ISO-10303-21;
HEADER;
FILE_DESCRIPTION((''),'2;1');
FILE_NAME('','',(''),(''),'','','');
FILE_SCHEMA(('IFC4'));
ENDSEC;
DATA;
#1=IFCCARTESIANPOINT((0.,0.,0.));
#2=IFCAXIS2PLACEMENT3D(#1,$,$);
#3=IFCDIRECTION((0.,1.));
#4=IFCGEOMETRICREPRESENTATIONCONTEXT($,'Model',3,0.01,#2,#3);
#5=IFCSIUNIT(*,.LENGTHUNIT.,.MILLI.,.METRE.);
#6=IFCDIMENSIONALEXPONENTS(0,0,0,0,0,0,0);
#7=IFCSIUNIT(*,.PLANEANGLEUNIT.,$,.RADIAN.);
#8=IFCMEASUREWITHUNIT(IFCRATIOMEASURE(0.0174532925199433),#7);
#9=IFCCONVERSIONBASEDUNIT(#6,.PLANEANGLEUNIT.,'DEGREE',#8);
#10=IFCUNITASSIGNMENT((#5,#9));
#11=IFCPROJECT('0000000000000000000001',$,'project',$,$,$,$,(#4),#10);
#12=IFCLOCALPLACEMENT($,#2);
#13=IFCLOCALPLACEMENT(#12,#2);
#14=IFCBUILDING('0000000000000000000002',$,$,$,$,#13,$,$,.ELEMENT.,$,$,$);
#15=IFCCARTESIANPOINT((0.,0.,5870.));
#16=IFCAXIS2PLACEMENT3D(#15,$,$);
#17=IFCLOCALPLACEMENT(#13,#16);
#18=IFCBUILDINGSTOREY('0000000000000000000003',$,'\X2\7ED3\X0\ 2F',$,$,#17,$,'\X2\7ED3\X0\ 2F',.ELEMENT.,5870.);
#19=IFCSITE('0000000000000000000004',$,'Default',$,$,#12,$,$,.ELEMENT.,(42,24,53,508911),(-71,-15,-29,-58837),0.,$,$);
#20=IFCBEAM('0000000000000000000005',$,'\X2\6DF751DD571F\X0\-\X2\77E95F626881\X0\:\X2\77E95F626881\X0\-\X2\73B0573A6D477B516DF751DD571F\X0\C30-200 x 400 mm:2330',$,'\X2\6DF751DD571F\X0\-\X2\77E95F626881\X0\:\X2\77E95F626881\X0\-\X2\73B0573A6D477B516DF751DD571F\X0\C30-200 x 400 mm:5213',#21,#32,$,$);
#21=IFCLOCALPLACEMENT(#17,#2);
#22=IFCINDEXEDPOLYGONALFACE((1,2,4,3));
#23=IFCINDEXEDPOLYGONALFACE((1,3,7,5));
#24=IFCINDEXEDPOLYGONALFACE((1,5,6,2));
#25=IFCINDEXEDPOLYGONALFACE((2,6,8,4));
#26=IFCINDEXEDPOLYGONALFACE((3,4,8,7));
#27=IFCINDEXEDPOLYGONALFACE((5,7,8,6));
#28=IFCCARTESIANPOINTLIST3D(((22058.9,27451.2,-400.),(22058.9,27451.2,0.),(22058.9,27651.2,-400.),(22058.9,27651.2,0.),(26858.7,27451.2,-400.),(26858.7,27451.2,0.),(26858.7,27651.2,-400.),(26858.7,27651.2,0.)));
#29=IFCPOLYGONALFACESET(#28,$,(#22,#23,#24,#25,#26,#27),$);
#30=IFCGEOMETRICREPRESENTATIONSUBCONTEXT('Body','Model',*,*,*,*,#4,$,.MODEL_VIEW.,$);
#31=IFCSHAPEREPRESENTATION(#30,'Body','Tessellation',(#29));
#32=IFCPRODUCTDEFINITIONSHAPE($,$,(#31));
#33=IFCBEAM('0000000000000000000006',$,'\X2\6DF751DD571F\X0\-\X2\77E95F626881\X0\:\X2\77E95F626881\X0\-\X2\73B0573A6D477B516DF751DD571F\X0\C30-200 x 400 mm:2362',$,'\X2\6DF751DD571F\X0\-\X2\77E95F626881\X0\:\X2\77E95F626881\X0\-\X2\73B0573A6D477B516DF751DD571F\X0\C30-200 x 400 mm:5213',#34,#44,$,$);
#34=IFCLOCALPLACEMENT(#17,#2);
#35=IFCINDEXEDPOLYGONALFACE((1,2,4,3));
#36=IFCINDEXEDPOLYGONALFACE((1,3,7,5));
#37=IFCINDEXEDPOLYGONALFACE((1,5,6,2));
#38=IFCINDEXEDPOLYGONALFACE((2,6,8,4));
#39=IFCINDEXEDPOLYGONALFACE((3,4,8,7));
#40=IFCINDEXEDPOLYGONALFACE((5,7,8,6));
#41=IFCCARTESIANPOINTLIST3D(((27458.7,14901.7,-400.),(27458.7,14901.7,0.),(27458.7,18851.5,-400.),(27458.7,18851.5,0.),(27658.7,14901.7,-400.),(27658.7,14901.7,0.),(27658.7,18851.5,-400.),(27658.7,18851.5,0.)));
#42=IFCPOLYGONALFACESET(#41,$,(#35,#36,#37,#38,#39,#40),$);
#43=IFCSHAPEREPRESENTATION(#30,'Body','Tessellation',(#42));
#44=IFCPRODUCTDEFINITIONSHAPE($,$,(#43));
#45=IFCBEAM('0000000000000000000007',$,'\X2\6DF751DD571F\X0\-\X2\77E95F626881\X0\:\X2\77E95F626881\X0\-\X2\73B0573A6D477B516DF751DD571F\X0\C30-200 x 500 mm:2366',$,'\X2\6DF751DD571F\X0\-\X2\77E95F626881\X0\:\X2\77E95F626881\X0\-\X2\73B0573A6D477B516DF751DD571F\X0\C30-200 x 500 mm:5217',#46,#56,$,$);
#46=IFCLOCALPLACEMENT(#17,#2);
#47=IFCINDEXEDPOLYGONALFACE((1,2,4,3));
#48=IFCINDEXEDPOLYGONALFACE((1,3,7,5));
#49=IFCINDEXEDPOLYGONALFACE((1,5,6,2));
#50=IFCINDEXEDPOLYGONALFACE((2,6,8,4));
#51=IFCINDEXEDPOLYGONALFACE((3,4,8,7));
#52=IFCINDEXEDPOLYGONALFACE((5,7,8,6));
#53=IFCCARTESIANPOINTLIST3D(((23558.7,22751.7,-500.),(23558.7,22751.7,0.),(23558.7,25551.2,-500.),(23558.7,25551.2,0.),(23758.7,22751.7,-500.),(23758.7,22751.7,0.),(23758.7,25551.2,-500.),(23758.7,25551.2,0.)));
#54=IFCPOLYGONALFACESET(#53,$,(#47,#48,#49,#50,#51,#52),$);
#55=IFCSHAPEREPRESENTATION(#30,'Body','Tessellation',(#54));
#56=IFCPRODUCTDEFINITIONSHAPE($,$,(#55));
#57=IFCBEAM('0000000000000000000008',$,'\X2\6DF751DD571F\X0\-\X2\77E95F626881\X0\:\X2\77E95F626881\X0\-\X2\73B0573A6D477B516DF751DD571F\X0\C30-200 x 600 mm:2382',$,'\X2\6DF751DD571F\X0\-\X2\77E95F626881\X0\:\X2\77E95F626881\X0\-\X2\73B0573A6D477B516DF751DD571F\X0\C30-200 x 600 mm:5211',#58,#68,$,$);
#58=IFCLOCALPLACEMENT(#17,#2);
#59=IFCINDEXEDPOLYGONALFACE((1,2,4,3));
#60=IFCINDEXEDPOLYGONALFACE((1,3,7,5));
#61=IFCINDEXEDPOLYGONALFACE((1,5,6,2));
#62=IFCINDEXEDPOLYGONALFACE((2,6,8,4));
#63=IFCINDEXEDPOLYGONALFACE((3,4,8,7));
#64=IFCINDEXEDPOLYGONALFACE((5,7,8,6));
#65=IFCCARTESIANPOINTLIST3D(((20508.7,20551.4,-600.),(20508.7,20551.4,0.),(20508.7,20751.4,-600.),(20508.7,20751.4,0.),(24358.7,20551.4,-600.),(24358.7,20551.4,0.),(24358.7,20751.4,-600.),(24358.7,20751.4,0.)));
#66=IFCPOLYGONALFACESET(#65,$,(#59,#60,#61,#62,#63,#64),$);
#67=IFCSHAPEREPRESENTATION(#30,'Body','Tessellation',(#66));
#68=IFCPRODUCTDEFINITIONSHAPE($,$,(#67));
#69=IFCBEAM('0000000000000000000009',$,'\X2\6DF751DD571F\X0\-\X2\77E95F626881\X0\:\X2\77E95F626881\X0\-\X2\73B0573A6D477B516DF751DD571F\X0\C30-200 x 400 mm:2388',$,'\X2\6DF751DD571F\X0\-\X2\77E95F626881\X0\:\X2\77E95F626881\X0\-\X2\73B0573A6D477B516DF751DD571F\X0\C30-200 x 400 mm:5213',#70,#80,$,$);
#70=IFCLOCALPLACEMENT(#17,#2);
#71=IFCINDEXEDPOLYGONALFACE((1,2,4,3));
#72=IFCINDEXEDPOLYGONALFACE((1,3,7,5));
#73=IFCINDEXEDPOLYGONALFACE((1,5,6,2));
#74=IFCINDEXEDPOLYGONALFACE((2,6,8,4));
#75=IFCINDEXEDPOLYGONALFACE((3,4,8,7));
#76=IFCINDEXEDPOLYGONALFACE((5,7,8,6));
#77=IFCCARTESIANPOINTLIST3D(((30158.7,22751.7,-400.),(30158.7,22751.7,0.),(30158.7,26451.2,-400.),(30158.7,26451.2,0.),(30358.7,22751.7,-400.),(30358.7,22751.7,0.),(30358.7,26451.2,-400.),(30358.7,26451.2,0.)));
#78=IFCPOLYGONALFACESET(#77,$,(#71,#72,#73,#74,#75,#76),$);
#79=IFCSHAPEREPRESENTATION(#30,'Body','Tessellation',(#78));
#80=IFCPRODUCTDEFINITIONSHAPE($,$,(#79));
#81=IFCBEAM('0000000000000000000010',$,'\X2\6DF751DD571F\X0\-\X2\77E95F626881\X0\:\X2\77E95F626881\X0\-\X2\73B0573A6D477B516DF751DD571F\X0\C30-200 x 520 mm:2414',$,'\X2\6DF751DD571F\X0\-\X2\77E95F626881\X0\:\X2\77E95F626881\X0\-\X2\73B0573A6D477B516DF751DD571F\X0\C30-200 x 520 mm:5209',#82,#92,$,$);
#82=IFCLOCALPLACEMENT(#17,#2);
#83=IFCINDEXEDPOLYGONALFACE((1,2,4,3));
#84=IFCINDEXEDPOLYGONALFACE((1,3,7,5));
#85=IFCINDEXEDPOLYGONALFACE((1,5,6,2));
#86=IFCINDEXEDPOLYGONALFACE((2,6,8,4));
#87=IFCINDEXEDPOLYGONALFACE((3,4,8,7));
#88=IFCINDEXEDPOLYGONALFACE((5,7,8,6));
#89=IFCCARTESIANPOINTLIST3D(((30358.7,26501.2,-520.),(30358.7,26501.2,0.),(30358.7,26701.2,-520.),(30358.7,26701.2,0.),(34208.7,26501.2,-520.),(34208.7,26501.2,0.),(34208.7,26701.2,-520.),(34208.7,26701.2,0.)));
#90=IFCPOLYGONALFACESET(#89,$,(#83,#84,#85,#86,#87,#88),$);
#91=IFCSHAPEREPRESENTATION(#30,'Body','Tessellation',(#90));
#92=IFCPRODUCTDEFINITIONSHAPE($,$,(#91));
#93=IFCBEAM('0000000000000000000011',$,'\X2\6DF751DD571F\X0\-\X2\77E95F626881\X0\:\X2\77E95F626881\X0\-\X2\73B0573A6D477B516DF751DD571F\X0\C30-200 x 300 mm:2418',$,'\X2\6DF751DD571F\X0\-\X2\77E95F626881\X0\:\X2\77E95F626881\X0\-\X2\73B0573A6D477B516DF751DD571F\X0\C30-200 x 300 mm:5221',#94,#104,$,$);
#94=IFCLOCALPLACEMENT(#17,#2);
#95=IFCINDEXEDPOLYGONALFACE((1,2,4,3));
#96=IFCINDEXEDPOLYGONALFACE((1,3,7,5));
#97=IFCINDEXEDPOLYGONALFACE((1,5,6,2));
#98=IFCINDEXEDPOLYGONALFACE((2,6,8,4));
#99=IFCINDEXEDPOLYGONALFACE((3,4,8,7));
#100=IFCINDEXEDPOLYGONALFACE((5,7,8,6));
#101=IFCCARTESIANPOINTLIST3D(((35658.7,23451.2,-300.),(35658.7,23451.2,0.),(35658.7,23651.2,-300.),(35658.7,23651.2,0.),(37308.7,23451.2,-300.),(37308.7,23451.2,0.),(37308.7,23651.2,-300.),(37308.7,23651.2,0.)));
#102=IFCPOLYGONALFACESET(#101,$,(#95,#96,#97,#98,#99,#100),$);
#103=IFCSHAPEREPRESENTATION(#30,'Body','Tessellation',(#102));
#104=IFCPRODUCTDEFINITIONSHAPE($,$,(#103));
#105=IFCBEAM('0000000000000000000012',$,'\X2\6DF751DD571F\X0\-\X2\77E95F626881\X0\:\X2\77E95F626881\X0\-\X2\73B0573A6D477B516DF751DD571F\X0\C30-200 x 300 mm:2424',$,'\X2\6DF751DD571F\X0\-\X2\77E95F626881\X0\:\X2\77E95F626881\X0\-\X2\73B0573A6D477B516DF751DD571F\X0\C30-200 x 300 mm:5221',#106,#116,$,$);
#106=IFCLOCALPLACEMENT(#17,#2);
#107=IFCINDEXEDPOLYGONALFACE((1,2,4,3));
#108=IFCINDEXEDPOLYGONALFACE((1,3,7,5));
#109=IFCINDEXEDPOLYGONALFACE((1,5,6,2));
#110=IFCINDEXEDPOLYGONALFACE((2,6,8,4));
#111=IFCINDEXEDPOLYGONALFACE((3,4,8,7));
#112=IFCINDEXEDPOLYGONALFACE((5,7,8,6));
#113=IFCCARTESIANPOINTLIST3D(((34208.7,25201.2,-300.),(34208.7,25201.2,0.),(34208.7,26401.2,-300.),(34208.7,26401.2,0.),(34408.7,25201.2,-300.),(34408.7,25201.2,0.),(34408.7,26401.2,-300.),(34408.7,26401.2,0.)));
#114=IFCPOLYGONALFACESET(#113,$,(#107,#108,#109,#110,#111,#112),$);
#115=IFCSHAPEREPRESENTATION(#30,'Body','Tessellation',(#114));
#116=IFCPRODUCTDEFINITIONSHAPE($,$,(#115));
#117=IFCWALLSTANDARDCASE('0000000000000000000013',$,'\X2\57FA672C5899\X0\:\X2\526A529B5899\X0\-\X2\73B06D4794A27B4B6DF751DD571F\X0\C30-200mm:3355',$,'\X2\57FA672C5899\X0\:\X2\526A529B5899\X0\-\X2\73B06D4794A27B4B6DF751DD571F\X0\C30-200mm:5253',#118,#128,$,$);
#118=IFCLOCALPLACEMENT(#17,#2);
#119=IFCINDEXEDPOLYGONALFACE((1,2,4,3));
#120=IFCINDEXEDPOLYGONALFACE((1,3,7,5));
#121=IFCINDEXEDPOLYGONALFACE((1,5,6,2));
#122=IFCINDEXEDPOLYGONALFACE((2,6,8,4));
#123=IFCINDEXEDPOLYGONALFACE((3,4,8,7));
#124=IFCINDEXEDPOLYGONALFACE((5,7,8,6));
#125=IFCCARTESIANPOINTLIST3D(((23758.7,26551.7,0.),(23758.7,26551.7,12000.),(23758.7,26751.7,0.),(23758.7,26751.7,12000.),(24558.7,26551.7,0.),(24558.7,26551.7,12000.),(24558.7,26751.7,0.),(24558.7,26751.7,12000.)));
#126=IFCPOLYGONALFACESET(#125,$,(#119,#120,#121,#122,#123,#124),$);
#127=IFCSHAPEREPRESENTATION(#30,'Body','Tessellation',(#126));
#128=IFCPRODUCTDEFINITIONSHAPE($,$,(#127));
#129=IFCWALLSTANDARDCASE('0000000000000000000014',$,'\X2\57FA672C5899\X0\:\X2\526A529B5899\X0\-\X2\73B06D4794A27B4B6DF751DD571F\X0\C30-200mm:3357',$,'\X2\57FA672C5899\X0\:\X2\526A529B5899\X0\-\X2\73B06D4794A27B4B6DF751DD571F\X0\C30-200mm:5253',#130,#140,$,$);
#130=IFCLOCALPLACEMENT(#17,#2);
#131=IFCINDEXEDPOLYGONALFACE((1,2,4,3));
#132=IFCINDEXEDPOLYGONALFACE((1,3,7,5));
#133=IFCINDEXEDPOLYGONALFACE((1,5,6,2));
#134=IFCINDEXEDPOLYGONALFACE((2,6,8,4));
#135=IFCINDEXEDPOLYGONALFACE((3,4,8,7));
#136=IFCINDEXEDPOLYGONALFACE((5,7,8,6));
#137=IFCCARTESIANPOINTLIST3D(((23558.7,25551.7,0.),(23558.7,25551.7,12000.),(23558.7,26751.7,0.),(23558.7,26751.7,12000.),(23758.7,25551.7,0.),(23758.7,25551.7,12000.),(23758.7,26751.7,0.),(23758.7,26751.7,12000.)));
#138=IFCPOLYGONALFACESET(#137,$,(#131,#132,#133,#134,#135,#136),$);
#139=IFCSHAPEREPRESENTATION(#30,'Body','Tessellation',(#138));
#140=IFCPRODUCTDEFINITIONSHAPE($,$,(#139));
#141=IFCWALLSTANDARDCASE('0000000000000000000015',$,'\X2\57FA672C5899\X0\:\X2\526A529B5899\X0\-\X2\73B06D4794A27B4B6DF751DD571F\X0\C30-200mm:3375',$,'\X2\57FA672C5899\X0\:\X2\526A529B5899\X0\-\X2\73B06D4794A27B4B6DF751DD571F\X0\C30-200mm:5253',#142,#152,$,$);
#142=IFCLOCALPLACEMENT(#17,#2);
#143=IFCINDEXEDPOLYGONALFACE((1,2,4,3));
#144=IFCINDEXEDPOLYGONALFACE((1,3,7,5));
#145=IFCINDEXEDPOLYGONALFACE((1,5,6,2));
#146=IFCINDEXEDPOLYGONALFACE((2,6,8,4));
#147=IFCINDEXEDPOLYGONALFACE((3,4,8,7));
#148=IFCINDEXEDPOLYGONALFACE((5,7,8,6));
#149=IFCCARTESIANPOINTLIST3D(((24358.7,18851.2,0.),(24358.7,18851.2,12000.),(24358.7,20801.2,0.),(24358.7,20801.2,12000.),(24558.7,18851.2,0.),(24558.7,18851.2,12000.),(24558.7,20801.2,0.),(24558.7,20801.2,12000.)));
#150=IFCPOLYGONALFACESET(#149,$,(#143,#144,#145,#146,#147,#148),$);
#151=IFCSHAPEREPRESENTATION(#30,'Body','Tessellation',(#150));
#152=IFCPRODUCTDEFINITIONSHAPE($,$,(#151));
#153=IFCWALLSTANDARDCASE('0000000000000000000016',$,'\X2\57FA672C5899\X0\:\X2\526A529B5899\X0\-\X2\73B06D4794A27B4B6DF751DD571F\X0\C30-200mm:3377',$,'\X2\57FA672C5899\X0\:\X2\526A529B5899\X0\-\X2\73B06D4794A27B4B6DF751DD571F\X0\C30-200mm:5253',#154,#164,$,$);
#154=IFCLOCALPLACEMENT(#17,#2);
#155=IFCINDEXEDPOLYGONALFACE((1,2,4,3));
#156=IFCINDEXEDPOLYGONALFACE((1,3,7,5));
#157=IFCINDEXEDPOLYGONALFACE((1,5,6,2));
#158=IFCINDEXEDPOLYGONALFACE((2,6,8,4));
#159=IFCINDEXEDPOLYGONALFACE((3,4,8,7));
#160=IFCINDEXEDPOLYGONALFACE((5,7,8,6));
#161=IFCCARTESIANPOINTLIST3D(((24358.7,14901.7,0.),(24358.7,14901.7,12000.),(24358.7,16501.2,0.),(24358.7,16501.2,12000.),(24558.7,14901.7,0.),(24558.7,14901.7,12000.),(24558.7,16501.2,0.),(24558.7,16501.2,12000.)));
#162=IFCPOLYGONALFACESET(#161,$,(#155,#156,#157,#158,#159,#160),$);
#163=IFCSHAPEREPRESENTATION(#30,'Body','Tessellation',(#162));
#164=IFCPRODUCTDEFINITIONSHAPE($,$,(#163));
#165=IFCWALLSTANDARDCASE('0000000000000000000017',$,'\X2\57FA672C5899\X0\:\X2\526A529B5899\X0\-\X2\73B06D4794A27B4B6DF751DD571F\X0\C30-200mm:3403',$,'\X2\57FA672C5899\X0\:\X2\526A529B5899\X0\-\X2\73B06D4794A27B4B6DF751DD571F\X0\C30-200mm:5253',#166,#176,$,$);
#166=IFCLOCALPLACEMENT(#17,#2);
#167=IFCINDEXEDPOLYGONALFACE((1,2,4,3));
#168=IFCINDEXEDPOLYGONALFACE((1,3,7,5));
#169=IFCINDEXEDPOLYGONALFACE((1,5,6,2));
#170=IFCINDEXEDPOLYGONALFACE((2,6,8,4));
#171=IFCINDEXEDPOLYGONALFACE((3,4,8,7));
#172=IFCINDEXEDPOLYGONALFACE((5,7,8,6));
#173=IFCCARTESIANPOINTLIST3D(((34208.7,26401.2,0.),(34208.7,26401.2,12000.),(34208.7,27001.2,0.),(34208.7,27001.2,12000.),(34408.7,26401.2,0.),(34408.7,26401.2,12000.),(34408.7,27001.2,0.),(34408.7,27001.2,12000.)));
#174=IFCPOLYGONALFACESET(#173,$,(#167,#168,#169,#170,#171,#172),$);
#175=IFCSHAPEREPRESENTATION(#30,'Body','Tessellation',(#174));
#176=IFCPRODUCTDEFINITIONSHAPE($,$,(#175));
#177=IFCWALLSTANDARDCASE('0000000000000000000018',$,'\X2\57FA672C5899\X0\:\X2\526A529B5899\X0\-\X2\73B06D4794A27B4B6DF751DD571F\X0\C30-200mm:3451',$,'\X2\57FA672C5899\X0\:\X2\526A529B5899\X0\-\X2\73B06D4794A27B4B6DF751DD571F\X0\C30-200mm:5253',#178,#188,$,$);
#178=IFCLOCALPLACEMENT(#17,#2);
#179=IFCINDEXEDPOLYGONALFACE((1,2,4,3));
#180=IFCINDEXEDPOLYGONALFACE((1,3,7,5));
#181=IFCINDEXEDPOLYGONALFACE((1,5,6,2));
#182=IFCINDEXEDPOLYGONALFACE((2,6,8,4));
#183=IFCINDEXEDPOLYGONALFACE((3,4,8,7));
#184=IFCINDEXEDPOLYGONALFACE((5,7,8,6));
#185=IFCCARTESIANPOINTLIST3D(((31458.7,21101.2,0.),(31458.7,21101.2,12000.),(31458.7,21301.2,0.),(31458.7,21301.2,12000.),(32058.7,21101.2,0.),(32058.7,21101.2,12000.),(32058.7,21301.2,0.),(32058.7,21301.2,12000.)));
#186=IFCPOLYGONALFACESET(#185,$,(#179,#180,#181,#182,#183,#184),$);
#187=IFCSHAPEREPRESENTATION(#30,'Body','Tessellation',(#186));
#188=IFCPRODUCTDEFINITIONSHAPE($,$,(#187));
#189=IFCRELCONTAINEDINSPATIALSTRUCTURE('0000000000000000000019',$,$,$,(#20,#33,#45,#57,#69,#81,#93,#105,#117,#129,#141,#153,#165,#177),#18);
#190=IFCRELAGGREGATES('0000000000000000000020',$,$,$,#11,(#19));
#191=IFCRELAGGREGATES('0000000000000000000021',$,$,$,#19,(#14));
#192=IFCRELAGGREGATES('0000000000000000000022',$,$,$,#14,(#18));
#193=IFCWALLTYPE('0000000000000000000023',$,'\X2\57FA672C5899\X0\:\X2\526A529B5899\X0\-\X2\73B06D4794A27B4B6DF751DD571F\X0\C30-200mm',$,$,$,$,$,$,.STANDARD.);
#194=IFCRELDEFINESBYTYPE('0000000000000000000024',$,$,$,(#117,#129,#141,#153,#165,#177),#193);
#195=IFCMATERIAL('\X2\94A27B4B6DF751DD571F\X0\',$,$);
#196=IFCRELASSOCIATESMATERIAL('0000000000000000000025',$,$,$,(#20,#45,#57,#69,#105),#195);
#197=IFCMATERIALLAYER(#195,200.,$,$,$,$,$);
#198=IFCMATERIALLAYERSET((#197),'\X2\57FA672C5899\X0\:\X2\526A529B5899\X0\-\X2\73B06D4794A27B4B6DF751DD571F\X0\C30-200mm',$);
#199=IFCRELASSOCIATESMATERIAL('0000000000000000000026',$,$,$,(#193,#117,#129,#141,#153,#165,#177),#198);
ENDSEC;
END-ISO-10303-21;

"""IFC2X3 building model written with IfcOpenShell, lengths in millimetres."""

from ifc_helpers import new_model, entity, si_unit, converted_unit, direction, frame, frame_2d, origin, place, context, subcontext, project, spatial, rectangle, extrude, material, layer, layer_set, layer_usage, type_object, element, save


model = new_model("IFC2X3")

# Units and contexts
model_context = context("Model", 3, precision=0.01, world=origin(), true_north=direction((0.0, 1.0)))
body_context = subcontext(model_context, "Body", "Model", "MODEL_VIEW")
ifc_project = project(units=[si_unit("LENGTHUNIT", "METRE", prefix="MILLI"), converted_unit("PLANEANGLEUNIT", "DEGREE", entity("IfcRatioMeasure", 0.0174532925199433), si_unit("PLANEANGLEUNIT", "RADIAN"), dimensions=[0, 0, 0, 0, 0, 0, 0])], contexts=[model_context])

# Site, building, storey
site_placement = place(None, origin())
site = spatial("IfcSite", under=ifc_project, at=site_placement, Name="Default", CompositionType="ELEMENT", RefLatitude=(42, 24, 53, 508911), RefLongitude=(-71, -15, -29, -58837), RefElevation=0.0)
building_placement = place(site_placement, origin())
building = spatial("IfcBuilding", under=site, at=building_placement, CompositionType="ELEMENT")
storey_placement = place(building_placement, frame((0.0, 0.0, 5870.0)))
storey = spatial("IfcBuildingStorey", under=building, at=storey_placement, Name="结 2F", LongName="结 2F", CompositionType="ELEMENT", Elevation=5870.0)

# Beams
ifc_material = material(Name="钢筋混凝土")
beam_1_placement = place(storey_placement, frame((26958.7, 27551.2, 0.0), z_axis=(0.0, 0.0, 1.0), x_axis=(-1.0, 0.0, 0.0)))
element("IfcBeam", 1, at=beam_1_placement, inside=storey, material=ifc_material, Name="混凝土-矩形梁:矩形梁-现场浇筑混凝土C30-200 x 400 mm:2330", ObjectType="混凝土-矩形梁:矩形梁-现场浇筑混凝土C30-200 x 400 mm:5213", context=body_context, shape_type="SweptSolid", body=[
    extrude(rectangle(XDim=400.0, YDim=200.0, at=frame_2d((0.0, 0.0), x_axis=(1.0, 0.0))), frame((100.0, 0.0, -200.0), z_axis=(1.0, 0.0, 0.0), x_axis=(0.0, 0.0, -1.0)), (0.0, 0.0, 1.0), 4799.8),
])
beam_2_placement = place(storey_placement, frame((27558.7, 14801.7, 0.0), z_axis=(0.0, 0.0, 1.0), x_axis=(0.0, 1.0, 0.0)))
element("IfcBeam", 2, at=beam_2_placement, inside=storey, Name="混凝土-矩形梁:矩形梁-现场浇筑混凝土C30-200 x 400 mm:2362", ObjectType="混凝土-矩形梁:矩形梁-现场浇筑混凝土C30-200 x 400 mm:5213", context=body_context, shape_type="SweptSolid", body=[
    extrude(rectangle(XDim=400.0, YDim=200.0, at=frame_2d((0.0, 0.0), x_axis=(1.0, 0.0))), frame((100.0, 0.0, -200.0), z_axis=(1.0, 0.0, 0.0), x_axis=(0.0, 0.0, -1.0)), (0.0, 0.0, 1.0), 3949.8),
])
beam_3_placement = place(storey_placement, frame((23658.7, 22651.7, 0.0), z_axis=(0.0, 0.0, 1.0), x_axis=(0.0, 1.0, 0.0)))
element("IfcBeam", 3, at=beam_3_placement, inside=storey, material=ifc_material, Name="混凝土-矩形梁:矩形梁-现场浇筑混凝土C30-200 x 500 mm:2366", ObjectType="混凝土-矩形梁:矩形梁-现场浇筑混凝土C30-200 x 500 mm:5217", context=body_context, shape_type="SweptSolid", body=[
    extrude(rectangle(XDim=500.0, YDim=200.0, at=frame_2d((0.0, 0.0), x_axis=(1.0, 0.0))), frame((100.0, 0.0, -250.0), z_axis=(1.0, 0.0, 0.0), x_axis=(0.0, 0.0, -1.0)), (0.0, 0.0, 1.0), 2799.5),
])
beam_4_placement = place(storey_placement, frame((24458.7, 20651.4, 0.0), z_axis=(0.0, 0.0, 1.0), x_axis=(-1.0, 0.0, 0.0)))
element("IfcBeam", 4, at=beam_4_placement, inside=storey, material=ifc_material, Name="混凝土-矩形梁:矩形梁-现场浇筑混凝土C30-200 x 600 mm:2382", ObjectType="混凝土-矩形梁:矩形梁-现场浇筑混凝土C30-200 x 600 mm:5211", context=body_context, shape_type="SweptSolid", body=[
    extrude(rectangle(XDim=600.0, YDim=200.0, at=frame_2d((0.0, 0.0), x_axis=(1.0, 0.0))), frame((100.0, 0.0, -300.0), z_axis=(1.0, 0.0, 0.0), x_axis=(0.0, 0.0, -1.0)), (0.0, 0.0, 1.0), 3850.0),
])
beam_5_placement = place(storey_placement, frame((30258.7, 22651.7, 0.0), z_axis=(0.0, 0.0, 1.0), x_axis=(0.0, 1.0, 0.0)))
element("IfcBeam", 5, at=beam_5_placement, inside=storey, material=ifc_material, Name="混凝土-矩形梁:矩形梁-现场浇筑混凝土C30-200 x 400 mm:2388", ObjectType="混凝土-矩形梁:矩形梁-现场浇筑混凝土C30-200 x 400 mm:5213", context=body_context, shape_type="SweptSolid", body=[
    extrude(rectangle(XDim=400.0, YDim=200.0, at=frame_2d((0.0, 0.0), x_axis=(1.0, 0.0))), frame((100.0, 0.0, -200.0), z_axis=(1.0, 0.0, 0.0), x_axis=(0.0, 0.0, -1.0)), (0.0, 0.0, 1.0), 3699.5),
])
beam_6_placement = place(storey_placement, frame((30258.7, 26601.2, 0.0)))
element("IfcBeam", 6, at=beam_6_placement, inside=storey, Name="混凝土-矩形梁:矩形梁-现场浇筑混凝土C30-200 x 520 mm:2414", ObjectType="混凝土-矩形梁:矩形梁-现场浇筑混凝土C30-200 x 520 mm:5209", context=body_context, shape_type="SweptSolid", body=[
    extrude(rectangle(XDim=520.0, YDim=200.0, at=frame_2d((0.0, 0.0), x_axis=(1.0, 0.0))), frame((100.0, 0.0, -260.0), z_axis=(1.0, 0.0, 0.0), x_axis=(0.0, 0.0, -1.0)), (0.0, 0.0, 1.0), 3850.0),
])
beam_7_placement = place(storey_placement, frame((35558.7, 23551.2, 0.0)))
element("IfcBeam", 7, at=beam_7_placement, inside=storey, Name="混凝土-矩形梁:矩形梁-现场浇筑混凝土C30-200 x 300 mm:2418", ObjectType="混凝土-矩形梁:矩形梁-现场浇筑混凝土C30-200 x 300 mm:5221", context=body_context, shape_type="SweptSolid", body=[
    extrude(rectangle(XDim=300.0, YDim=200.0, at=frame_2d((0.0, 0.0), x_axis=(1.0, 0.0))), frame((100.0, 0.0, -150.0), z_axis=(1.0, 0.0, 0.0), x_axis=(0.0, 0.0, -1.0)), (0.0, 0.0, 1.0), 1650.0),
])
beam_8_placement = place(storey_placement, frame((34308.7, 25101.2, 0.0), z_axis=(0.0, 0.0, 1.0), x_axis=(0.0, 1.0, 0.0)))
element("IfcBeam", 8, at=beam_8_placement, inside=storey, material=ifc_material, Name="混凝土-矩形梁:矩形梁-现场浇筑混凝土C30-200 x 300 mm:2424", ObjectType="混凝土-矩形梁:矩形梁-现场浇筑混凝土C30-200 x 300 mm:5221", context=body_context, shape_type="SweptSolid", body=[
    extrude(rectangle(XDim=300.0, YDim=200.0, at=frame_2d((0.0, 0.0), x_axis=(1.0, 0.0))), frame((100.0, 0.0, -150.0), z_axis=(1.0, 0.0, 0.0), x_axis=(0.0, 0.0, -1.0)), (0.0, 0.0, 1.0), 1200.0),
])

# Walls
ifc_layer = layer(ifc_material, 200.0)
ifc_layer_set = layer_set([ifc_layer], Name="基本墙:剪力墙-现浇钢筋混凝土C30-200mm")
ifc_layer_usage_1 = layer_usage(ifc_layer_set, "AXIS2", "POSITIVE", -100.0)
wall_type = type_object("IfcWallType", Name="基本墙:剪力墙-现浇钢筋混凝土C30-200mm", PredefinedType="STANDARD", material=ifc_layer_set)
wall_1_placement = place(storey_placement, frame((24558.7, 26651.7, 0.0), z_axis=(0.0, 0.0, 1.0), x_axis=(-1.0, 0.0, 0.0)))
element("IfcWallStandardCase", 9, at=wall_1_placement, inside=storey, type_object=wall_type, material=ifc_layer_usage_1, Name="基本墙:剪力墙-现浇钢筋混凝土C30-200mm:3355", ObjectType="基本墙:剪力墙-现浇钢筋混凝土C30-200mm:5253", context=body_context, shape_type="SweptSolid", body=[
    extrude(rectangle(XDim=800.0, YDim=200.0, at=frame_2d((400.0, 0.0), x_axis=(-1.0, 0.0))), origin(), (0.0, 0.0, 1.0), 12000.0),
])
ifc_layer_usage_2 = layer_usage(ifc_layer_set, "AXIS2", "POSITIVE", -100.0)
wall_2_placement = place(storey_placement, frame((23658.7, 26751.7, 0.0), z_axis=(0.0, 0.0, 1.0), x_axis=(0.0, -1.0, 0.0)))
element("IfcWallStandardCase", 10, at=wall_2_placement, inside=storey, type_object=wall_type, material=ifc_layer_usage_2, Name="基本墙:剪力墙-现浇钢筋混凝土C30-200mm:3357", ObjectType="基本墙:剪力墙-现浇钢筋混凝土C30-200mm:5253", context=body_context, shape_type="SweptSolid", body=[
    extrude(rectangle(XDim=1200.0, YDim=200.0, at=frame_2d((600.0, 0.0), x_axis=(-1.0, 0.0))), origin(), (0.0, 0.0, 1.0), 12000.0),
])
ifc_layer_usage_3 = layer_usage(ifc_layer_set, "AXIS2", "POSITIVE", -100.0)
wall_3_placement = place(storey_placement, frame((24458.7, 20801.2, 0.0), z_axis=(0.0, 0.0, 1.0), x_axis=(0.0, -1.0, 0.0)))
element("IfcWallStandardCase", 11, at=wall_3_placement, inside=storey, type_object=wall_type, material=ifc_layer_usage_3, Name="基本墙:剪力墙-现浇钢筋混凝土C30-200mm:3375", ObjectType="基本墙:剪力墙-现浇钢筋混凝土C30-200mm:5253", context=body_context, shape_type="SweptSolid", body=[
    extrude(rectangle(XDim=1950.0, YDim=200.0, at=frame_2d((975.0, 0.0), x_axis=(-1.0, 0.0))), origin(), (0.0, 0.0, 1.0), 12000.0),
])
ifc_layer_usage_4 = layer_usage(ifc_layer_set, "AXIS2", "POSITIVE", -100.0)
wall_4_placement = place(storey_placement, frame((24458.7, 16501.2, 0.0), z_axis=(0.0, 0.0, 1.0), x_axis=(0.0, -1.0, 0.0)))
element("IfcWallStandardCase", 12, at=wall_4_placement, inside=storey, type_object=wall_type, material=ifc_layer_usage_4, Name="基本墙:剪力墙-现浇钢筋混凝土C30-200mm:3377", ObjectType="基本墙:剪力墙-现浇钢筋混凝土C30-200mm:5253", context=body_context, shape_type="SweptSolid", body=[
    extrude(rectangle(XDim=1599.5, YDim=200.0, at=frame_2d((799.8, 0.0), x_axis=(-1.0, 0.0))), origin(), (0.0, 0.0, 1.0), 12000.0),
])
ifc_layer_usage_5 = layer_usage(ifc_layer_set, "AXIS2", "NEGATIVE", 100.0)
wall_5_placement = place(storey_placement, frame((34308.7, 26401.2, 0.0), z_axis=(0.0, 0.0, 1.0), x_axis=(0.0, 1.0, 0.0)))
element("IfcWallStandardCase", 13, at=wall_5_placement, inside=storey, type_object=wall_type, material=ifc_layer_usage_5, Name="基本墙:剪力墙-现浇钢筋混凝土C30-200mm:3403", ObjectType="基本墙:剪力墙-现浇钢筋混凝土C30-200mm:5253", context=body_context, shape_type="SweptSolid", body=[
    extrude(rectangle(XDim=600.0, YDim=200.0, at=frame_2d((300.0, 0.0), x_axis=(-1.0, 0.0))), origin(), (0.0, 0.0, 1.0), 12000.0),
])
ifc_layer_usage_6 = layer_usage(ifc_layer_set, "AXIS2", "NEGATIVE", 100.0)
wall_6_placement = place(storey_placement, frame((31458.7, 21201.2, 0.0)))
element("IfcWallStandardCase", 14, at=wall_6_placement, inside=storey, type_object=wall_type, material=ifc_layer_usage_6, Name="基本墙:剪力墙-现浇钢筋混凝土C30-200mm:3451", ObjectType="基本墙:剪力墙-现浇钢筋混凝土C30-200mm:5253", context=body_context, shape_type="SweptSolid", body=[
    extrude(rectangle(XDim=600.0, YDim=200.0, at=frame_2d((300.0, 0.0), x_axis=(-1.0, 0.0))), origin(), (0.0, 0.0, 1.0), 12000.0),
])

save(model, "model.ifc")
